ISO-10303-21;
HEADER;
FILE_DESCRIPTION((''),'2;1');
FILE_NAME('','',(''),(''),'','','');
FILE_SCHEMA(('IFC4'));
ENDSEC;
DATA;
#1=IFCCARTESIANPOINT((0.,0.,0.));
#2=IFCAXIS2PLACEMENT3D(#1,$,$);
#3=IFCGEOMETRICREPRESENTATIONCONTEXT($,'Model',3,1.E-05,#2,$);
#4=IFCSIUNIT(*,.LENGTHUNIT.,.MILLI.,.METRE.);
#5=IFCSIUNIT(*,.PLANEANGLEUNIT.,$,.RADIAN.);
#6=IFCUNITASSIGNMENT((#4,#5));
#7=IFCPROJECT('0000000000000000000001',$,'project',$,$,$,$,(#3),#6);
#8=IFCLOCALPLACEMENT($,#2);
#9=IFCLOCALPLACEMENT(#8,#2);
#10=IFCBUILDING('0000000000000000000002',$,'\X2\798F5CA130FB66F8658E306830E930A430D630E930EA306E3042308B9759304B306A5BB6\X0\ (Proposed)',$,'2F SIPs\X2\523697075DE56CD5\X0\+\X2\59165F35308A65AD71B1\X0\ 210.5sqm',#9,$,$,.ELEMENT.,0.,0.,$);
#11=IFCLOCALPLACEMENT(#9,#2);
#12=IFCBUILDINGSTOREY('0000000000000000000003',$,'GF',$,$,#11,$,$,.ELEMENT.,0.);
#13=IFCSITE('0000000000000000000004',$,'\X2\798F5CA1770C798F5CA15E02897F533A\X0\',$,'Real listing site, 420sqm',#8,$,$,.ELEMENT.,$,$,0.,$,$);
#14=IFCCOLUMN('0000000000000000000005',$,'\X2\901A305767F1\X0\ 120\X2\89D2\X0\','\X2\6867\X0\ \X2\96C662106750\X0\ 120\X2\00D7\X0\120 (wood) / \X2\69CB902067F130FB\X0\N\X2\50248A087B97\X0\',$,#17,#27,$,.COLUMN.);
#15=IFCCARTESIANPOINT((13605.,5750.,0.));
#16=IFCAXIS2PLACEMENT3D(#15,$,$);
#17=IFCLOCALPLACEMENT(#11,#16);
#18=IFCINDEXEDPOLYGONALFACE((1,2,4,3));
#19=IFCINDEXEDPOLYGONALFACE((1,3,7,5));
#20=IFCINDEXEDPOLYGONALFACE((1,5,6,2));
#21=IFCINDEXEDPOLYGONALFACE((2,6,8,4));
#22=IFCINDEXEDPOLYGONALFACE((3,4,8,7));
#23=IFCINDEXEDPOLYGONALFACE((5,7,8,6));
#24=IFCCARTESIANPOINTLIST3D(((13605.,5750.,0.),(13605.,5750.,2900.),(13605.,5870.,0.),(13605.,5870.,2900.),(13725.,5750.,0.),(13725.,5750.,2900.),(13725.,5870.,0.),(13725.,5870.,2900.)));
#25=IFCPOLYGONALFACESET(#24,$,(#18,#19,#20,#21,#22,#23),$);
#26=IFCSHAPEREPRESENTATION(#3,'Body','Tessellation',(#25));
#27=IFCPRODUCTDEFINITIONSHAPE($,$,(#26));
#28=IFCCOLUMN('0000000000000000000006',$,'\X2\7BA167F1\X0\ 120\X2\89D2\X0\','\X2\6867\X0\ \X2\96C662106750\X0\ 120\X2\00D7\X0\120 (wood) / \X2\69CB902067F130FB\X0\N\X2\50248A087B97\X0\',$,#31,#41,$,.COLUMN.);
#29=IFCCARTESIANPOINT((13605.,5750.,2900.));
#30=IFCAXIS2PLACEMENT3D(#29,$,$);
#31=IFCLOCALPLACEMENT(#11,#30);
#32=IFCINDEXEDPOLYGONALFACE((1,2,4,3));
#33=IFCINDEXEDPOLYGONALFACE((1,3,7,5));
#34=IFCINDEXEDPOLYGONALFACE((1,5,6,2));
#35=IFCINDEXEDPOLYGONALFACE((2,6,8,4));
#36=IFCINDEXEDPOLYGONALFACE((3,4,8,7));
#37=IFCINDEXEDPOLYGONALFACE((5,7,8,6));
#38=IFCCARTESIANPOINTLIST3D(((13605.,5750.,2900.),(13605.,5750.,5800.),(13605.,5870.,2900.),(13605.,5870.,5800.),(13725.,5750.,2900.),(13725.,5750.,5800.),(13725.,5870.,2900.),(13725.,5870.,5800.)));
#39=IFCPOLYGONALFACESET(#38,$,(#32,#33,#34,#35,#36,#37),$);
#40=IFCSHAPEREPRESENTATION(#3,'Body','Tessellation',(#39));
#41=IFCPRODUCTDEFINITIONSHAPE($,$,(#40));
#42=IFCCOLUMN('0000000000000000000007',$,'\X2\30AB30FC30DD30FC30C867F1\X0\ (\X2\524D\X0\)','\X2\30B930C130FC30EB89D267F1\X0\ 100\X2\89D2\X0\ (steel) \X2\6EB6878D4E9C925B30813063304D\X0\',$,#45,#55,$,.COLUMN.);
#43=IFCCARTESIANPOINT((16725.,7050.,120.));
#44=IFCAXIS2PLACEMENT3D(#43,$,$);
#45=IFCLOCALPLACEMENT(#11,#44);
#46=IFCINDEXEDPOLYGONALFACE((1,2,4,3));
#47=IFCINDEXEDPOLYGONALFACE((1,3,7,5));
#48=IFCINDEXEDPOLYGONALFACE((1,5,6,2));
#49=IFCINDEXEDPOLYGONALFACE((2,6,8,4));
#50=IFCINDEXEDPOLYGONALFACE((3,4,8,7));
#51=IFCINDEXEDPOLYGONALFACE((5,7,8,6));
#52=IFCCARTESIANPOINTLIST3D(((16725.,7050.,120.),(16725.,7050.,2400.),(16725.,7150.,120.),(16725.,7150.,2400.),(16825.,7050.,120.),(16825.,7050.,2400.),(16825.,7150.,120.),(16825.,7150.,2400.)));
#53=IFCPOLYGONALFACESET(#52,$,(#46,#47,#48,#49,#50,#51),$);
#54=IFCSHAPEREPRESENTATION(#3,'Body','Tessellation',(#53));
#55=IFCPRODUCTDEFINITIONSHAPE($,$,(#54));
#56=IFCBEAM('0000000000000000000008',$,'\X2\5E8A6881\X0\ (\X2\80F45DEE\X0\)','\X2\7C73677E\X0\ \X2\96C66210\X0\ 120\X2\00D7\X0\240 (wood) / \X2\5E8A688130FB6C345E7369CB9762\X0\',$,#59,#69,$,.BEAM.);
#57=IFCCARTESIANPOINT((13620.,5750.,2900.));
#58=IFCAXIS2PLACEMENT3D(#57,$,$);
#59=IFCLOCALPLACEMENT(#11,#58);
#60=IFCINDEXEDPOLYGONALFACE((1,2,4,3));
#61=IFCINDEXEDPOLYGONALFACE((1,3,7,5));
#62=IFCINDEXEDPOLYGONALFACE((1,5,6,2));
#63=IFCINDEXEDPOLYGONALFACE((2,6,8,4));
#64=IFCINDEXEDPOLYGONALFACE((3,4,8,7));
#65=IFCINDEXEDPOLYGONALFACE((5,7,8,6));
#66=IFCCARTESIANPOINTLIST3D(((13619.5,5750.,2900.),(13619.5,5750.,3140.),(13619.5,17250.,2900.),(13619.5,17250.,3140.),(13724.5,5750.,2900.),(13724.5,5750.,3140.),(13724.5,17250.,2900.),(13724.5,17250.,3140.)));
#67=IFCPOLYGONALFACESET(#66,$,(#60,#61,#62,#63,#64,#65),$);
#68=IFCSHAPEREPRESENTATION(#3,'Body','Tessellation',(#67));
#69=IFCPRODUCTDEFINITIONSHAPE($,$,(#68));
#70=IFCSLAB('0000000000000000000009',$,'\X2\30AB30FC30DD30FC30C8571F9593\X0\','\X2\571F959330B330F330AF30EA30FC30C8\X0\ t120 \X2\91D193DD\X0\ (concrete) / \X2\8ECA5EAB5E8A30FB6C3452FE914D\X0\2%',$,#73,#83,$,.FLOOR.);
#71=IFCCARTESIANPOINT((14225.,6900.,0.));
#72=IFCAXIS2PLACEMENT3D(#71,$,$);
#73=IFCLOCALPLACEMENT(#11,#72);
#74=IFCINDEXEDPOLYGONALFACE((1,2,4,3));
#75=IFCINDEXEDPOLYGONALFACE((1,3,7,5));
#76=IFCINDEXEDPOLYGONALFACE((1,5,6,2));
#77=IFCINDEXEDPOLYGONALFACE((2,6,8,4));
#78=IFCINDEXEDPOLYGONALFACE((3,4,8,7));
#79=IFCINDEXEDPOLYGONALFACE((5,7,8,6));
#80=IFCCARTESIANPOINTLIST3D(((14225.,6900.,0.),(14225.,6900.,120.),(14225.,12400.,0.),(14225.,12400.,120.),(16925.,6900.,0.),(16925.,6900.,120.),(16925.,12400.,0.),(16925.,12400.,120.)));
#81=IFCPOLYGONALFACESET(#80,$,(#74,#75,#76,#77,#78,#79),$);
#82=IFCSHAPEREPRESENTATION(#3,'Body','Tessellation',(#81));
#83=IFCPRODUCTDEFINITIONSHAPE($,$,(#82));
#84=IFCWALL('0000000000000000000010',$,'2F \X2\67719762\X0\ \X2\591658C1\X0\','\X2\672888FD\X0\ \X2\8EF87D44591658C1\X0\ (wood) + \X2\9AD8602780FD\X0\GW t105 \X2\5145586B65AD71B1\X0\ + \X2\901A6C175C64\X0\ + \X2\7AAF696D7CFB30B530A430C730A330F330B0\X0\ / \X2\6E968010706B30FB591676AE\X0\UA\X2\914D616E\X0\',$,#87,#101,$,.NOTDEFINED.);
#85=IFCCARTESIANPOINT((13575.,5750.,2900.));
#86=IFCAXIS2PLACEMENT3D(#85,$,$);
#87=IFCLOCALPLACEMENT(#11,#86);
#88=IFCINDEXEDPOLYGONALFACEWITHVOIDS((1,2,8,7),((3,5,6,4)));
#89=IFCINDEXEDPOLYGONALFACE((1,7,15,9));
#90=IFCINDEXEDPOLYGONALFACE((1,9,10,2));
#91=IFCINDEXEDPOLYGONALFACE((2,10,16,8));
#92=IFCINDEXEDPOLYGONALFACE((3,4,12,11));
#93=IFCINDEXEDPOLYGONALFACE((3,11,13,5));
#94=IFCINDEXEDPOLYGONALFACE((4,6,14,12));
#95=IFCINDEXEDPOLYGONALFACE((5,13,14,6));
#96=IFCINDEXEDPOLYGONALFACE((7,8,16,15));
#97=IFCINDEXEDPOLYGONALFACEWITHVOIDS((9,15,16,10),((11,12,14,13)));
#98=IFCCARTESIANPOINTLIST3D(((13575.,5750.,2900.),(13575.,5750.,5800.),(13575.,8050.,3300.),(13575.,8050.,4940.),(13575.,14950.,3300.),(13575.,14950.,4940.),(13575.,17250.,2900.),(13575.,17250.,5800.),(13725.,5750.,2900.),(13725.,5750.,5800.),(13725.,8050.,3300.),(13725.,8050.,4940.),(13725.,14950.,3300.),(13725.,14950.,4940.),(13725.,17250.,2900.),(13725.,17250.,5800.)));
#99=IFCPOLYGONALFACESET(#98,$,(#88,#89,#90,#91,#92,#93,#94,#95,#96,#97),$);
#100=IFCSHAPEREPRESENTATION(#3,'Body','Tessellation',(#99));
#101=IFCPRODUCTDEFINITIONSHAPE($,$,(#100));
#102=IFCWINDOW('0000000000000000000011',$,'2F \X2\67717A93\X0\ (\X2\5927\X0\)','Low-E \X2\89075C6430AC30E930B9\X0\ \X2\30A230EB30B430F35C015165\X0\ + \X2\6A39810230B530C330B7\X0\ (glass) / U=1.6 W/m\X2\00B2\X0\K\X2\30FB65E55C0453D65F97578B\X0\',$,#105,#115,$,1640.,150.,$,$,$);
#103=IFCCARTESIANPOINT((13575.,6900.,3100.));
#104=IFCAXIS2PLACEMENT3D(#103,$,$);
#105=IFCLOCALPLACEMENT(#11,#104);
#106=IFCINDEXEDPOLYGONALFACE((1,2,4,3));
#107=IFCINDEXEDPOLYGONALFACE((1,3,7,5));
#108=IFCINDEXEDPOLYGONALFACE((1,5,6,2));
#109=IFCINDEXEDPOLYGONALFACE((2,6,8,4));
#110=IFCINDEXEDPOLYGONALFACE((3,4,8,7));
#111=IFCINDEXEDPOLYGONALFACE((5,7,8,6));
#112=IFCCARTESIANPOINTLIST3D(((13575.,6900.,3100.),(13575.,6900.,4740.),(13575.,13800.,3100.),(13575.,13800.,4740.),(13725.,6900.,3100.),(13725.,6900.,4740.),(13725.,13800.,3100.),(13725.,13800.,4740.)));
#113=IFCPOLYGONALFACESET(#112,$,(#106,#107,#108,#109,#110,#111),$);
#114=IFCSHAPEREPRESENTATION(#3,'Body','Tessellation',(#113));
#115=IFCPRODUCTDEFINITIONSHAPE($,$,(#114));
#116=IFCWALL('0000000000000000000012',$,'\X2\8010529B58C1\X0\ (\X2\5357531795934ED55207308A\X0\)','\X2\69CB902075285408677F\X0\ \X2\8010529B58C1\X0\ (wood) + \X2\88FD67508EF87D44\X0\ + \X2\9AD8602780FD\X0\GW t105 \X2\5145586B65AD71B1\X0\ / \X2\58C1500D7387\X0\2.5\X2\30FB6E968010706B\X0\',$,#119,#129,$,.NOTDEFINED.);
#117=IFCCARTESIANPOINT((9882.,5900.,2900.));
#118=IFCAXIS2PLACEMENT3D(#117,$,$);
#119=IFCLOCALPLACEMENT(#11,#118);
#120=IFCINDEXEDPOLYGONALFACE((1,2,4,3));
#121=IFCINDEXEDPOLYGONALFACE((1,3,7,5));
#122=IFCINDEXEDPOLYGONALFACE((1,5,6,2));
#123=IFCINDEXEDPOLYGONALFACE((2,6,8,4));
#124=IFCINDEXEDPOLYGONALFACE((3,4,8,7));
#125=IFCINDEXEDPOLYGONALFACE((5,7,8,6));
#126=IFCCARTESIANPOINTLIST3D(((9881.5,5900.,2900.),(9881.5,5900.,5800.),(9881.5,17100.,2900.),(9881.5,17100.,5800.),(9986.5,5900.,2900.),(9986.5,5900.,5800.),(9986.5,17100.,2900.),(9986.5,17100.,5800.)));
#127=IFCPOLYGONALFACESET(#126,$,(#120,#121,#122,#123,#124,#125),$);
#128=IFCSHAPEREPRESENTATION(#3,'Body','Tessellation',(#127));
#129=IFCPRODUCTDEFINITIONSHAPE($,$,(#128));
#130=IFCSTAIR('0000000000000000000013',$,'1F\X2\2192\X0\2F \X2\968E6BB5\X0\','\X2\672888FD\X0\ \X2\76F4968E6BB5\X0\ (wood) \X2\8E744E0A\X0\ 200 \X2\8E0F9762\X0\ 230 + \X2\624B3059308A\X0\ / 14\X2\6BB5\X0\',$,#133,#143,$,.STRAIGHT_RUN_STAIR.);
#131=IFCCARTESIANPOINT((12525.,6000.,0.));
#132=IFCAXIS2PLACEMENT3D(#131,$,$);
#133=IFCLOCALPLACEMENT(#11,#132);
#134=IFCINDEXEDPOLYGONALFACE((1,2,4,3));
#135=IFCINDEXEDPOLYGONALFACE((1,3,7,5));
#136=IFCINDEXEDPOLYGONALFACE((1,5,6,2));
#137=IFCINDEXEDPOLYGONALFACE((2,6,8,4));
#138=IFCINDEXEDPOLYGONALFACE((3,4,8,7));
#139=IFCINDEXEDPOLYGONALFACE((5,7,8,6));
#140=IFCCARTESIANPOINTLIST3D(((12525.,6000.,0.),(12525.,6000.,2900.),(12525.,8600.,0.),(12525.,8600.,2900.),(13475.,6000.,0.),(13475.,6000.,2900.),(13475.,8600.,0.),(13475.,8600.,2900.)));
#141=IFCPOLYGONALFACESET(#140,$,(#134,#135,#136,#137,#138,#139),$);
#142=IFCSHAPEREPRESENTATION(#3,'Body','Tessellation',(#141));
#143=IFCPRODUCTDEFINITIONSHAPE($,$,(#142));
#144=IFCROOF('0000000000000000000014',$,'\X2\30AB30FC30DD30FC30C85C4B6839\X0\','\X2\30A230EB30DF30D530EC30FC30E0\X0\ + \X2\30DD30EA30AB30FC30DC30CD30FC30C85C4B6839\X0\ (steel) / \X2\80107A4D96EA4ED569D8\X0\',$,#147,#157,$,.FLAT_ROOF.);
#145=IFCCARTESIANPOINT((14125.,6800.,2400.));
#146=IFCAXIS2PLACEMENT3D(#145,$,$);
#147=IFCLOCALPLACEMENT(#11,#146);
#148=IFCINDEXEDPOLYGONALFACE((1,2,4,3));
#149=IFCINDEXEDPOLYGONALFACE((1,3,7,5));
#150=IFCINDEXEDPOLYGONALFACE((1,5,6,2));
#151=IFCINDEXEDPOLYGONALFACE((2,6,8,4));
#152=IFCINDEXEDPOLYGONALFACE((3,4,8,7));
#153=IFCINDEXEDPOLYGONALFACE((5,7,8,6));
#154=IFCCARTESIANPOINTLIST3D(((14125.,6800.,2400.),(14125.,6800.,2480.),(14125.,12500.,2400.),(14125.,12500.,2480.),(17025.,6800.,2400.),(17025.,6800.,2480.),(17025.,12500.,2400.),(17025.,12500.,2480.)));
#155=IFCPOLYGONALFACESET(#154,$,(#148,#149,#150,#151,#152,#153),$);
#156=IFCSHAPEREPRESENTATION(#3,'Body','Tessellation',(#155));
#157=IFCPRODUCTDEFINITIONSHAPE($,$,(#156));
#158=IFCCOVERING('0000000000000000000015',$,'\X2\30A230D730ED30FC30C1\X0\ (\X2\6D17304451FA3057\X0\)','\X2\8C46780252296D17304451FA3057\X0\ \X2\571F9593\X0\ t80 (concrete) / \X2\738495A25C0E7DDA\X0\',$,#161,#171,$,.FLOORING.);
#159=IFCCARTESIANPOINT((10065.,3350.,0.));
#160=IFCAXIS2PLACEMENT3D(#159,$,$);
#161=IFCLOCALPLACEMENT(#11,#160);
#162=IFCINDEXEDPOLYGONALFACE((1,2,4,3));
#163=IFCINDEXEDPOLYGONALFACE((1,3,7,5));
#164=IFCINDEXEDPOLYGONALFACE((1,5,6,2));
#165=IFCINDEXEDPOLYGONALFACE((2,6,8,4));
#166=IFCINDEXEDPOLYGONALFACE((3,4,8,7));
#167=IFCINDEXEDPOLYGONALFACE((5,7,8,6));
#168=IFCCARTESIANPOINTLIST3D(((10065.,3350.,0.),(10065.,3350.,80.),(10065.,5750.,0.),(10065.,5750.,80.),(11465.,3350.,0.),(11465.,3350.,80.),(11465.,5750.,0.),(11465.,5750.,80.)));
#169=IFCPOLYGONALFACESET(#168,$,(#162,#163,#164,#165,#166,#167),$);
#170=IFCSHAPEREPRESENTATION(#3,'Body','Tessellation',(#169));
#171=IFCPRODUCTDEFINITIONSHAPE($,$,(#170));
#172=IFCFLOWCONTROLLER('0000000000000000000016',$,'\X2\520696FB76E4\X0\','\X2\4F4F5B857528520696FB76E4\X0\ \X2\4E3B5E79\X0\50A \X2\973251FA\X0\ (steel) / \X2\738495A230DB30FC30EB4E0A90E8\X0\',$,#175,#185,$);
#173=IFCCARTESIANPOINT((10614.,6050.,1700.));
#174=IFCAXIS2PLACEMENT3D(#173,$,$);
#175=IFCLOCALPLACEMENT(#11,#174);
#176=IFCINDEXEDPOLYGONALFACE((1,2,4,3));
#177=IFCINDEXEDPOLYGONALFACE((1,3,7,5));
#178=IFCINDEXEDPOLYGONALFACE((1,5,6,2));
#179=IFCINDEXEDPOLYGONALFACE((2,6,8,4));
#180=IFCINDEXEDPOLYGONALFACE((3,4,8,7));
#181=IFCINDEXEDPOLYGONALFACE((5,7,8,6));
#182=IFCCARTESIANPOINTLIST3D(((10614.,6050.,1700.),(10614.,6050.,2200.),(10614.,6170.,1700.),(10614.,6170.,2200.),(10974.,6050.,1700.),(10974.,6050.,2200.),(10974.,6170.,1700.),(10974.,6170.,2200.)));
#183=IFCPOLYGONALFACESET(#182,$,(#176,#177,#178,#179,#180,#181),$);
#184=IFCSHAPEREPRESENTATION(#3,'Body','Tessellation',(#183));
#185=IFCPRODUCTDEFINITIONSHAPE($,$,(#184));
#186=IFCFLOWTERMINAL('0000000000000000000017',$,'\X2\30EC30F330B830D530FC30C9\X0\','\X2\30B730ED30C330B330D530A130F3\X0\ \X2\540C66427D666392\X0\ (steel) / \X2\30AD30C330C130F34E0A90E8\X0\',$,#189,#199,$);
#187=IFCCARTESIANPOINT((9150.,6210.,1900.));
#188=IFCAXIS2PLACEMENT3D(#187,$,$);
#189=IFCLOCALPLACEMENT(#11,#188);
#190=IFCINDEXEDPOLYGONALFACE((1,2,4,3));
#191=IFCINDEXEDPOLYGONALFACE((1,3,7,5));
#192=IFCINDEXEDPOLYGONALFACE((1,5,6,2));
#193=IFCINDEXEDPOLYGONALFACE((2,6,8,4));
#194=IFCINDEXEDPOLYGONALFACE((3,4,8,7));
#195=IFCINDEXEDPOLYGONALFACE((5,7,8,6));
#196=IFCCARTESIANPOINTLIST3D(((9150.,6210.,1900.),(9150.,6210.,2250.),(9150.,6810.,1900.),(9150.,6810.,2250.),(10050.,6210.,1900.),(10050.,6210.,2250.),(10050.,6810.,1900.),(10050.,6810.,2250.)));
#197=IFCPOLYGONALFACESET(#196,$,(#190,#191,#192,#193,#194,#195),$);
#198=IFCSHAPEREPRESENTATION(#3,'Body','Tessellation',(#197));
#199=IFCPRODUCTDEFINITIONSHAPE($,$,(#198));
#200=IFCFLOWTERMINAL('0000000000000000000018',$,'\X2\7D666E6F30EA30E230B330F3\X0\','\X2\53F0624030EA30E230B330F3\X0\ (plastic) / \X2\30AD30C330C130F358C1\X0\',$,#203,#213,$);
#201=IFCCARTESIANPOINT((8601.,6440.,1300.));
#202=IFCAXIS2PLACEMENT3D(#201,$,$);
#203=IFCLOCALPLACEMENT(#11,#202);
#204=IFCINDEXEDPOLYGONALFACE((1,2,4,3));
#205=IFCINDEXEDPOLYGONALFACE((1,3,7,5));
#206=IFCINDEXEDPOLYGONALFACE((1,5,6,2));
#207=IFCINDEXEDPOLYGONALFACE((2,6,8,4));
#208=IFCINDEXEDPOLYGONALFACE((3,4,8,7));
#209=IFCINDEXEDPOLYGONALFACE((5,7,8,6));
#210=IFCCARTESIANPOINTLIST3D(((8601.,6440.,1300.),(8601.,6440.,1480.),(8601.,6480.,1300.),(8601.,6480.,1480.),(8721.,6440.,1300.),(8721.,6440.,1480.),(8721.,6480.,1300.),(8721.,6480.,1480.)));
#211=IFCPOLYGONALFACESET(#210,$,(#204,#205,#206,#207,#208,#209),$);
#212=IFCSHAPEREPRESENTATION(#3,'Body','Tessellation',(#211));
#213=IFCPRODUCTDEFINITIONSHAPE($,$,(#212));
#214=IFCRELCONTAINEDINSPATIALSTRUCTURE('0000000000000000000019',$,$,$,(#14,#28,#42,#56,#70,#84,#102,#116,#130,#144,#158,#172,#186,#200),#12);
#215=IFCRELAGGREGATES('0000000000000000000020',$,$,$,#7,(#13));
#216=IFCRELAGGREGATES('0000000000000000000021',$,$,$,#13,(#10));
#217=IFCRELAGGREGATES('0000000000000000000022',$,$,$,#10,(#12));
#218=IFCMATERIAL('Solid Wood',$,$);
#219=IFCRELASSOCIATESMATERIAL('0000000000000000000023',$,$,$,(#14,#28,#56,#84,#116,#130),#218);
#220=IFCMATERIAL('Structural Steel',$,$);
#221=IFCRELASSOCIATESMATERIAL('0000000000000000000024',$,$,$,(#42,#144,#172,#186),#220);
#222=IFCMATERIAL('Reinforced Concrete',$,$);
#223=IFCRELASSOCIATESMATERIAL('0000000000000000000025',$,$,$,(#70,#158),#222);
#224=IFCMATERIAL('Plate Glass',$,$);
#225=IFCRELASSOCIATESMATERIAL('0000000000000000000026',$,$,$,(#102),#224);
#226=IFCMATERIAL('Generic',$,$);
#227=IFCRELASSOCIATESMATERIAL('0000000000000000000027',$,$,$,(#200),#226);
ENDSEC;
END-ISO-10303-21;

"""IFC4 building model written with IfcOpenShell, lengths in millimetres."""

from ifc_helpers import new_model, si_unit, frame, frame_2d, origin, place, context, project, spatial, rectangle, extrude, material, element, fill, save


model = new_model("IFC4")

# Units and contexts
model_context = context("Model", 3, precision=1e-05, world=origin())
ifc_project = project(units=[si_unit("LENGTHUNIT", "METRE", prefix="MILLI"), si_unit("PLANEANGLEUNIT", "RADIAN")], contexts=[model_context])

# Site, building, storey
site_placement = place(None, origin())
site = spatial("IfcSite", under=ifc_project, at=site_placement, Name="福岡県福岡市西区", ObjectType="Real listing site, 420sqm", CompositionType="ELEMENT", RefElevation=0.0)
building_placement = place(site_placement, origin())
building = spatial("IfcBuilding", under=site, at=building_placement, Name="福岡・書斎とライブラリのある静かな家 (Proposed)", ObjectType="2F SIPs制震工法+外張り断熱 210.5sqm", CompositionType="ELEMENT", ElevationOfRefHeight=0.0, ElevationOfTerrain=0.0)
storey_placement = place(building_placement, origin())
storey = spatial("IfcBuildingStorey", under=building, at=storey_placement, Name="GF", CompositionType="ELEMENT", Elevation=0.0)

# Columns
ifc_material_1 = material(Name="Solid Wood")
column_1_placement = place(storey_placement, frame((13605.0, 5750.0, 0.0)))
element("IfcColumn", 1, at=column_1_placement, inside=storey, material=ifc_material_1, Name="通し柱 120角", Description="桧 集成材 120×120 (wood) / 構造柱・N値計算", PredefinedType="COLUMN", context=model_context, shape_type="SweptSolid", body=[
    extrude(rectangle(XDim=120.0, YDim=120.0, at=frame_2d((60.0, 60.0))), frame((13605.0, 5750.0, 0.0)), (0.0, 0.0, 1.0), 2900.0),
])
column_2_placement = place(storey_placement, frame((13605.0, 5750.0, 2900.0)))
element("IfcColumn", 2, at=column_2_placement, inside=storey, material=ifc_material_1, Name="管柱 120角", Description="桧 集成材 120×120 (wood) / 構造柱・N値計算", PredefinedType="COLUMN", context=model_context, shape_type="SweptSolid", body=[
    extrude(rectangle(XDim=120.0, YDim=120.0, at=frame_2d((60.0, 60.0))), frame((13605.0, 5750.0, 2900.0)), (0.0, 0.0, 1.0), 2900.0),
])
ifc_material_2 = material(Name="Structural Steel")
column_3_placement = place(storey_placement, frame((16725.0, 7050.0, 120.0)))
element("IfcColumn", 3, at=column_3_placement, inside=storey, material=ifc_material_2, Name="カーポート柱 (前)", Description="スチール角柱 100角 (steel) 溶融亜鉛めっき", PredefinedType="COLUMN", context=model_context, shape_type="SweptSolid", body=[
    extrude(rectangle(XDim=100.0, YDim=100.0, at=frame_2d((50.0, 50.0))), frame((16725.0, 7050.0, 120.0)), (0.0, 0.0, 1.0), 2280.0),
])

# Beam
beam_1_placement = place(storey_placement, frame((13620.0, 5750.0, 2900.0)))
element("IfcBeam", 4, at=beam_1_placement, inside=storey, material=ifc_material_1, Name="床梁 (胴差)", Description="米松 集成 120×240 (wood) / 床梁・水平構面", PredefinedType="BEAM", context=model_context, shape_type="SweptSolid", body=[
    extrude(rectangle(XDim=105.0, YDim=11500.0, at=frame_2d((52.0, 5750.0))), frame((13620.0, 5750.0, 2900.0)), (0.0, 0.0, 1.0), 240.0),
])

# Slab
ifc_material_3 = material(Name="Reinforced Concrete")
slab_placement = place(storey_placement, frame((14225.0, 6900.0, 0.0)))
element("IfcSlab", 5, at=slab_placement, inside=storey, material=ifc_material_3, Name="カーポート土間", Description="土間コンクリート t120 金鏝 (concrete) / 車庫床・水勾配2%", PredefinedType="FLOOR", context=model_context, shape_type="SweptSolid", body=[
    extrude(rectangle(XDim=2700.0, YDim=5500.0, at=frame_2d((1350.0, 2750.0))), frame((14225.0, 6900.0, 0.0)), (0.0, 0.0, 1.0), 120.0),
])

# Shared definitions
ifc_material_4 = material(Name="Plate Glass")

# Wall, opening, window
wall_1_placement = place(storey_placement, frame((13575.0, 5750.0, 2900.0)))
wall_1 = element("IfcWall", 6, at=wall_1_placement, inside=storey, material=ifc_material_1, Name="2F 東面 外壁", Description="木製 軸組外壁 (wood) + 高性能GW t105 充填断熱 + 通気層 + 窯業系サイディング / 準耐火・外皮UA配慮", PredefinedType="NOTDEFINED", context=model_context, shape_type="SweptSolid", body=[
    extrude(rectangle(XDim=150.0, YDim=11500.0, at=frame_2d((75.0, 5750.0))), frame((13575.0, 5750.0, 2900.0)), (0.0, 0.0, 1.0), 2900.0),
])
opening_1_placement = place(storey_placement, frame((13575.0, 6900.0, 3100.0)))
opening_1 = element("IfcOpeningElement", 7, at=opening_1_placement, cuts=wall_1, PredefinedType="NOTDEFINED", context=model_context, shape_type="SweptSolid", body=[
    extrude(rectangle(XDim=150.0, YDim=6900.0, at=frame_2d((75.0, 3450.0))), frame((13575.0, 6900.0, 3100.0)), (0.0, 0.0, 1.0), 1640.0),
])
window_1_placement = place(storey_placement, frame((13575.0, 6900.0, 3100.0)))
window_1 = element("IfcWindow", 8, at=window_1_placement, inside=storey, material=ifc_material_4, Name="2F 東窓 (大)", Description="Low-E 複層ガラス アルゴン封入 + 樹脂サッシ (glass) / U=1.6 W/m²K・日射取得型", OverallHeight=1640.0, OverallWidth=150.0, context=model_context, shape_type="SweptSolid", body=[
    extrude(rectangle(XDim=150.0, YDim=6900.0, at=frame_2d((75.0, 3450.0))), frame((13575.0, 6900.0, 3100.0)), (0.0, 0.0, 1.0), 1640.0),
])
fill(opening_1, window_1)

# Wall
wall_2_placement = place(storey_placement, frame((9882.0, 5900.0, 2900.0)))
element("IfcWall", 9, at=wall_2_placement, inside=storey, material=ifc_material_1, Name="耐力壁 (南北間仕切り)", Description="構造用合板 耐力壁 (wood) + 製材軸組 + 高性能GW t105 充填断熱 / 壁倍率2.5・準耐火", PredefinedType="NOTDEFINED", context=model_context, shape_type="SweptSolid", body=[
    extrude(rectangle(XDim=105.0, YDim=11200.0, at=frame_2d((52.0, 5600.0))), frame((9882.0, 5900.0, 2900.0)), (0.0, 0.0, 1.0), 2900.0),
])

# Stair
stair_placement = place(storey_placement, frame((12525.0, 6000.0, 0.0)))
element("IfcStair", 10, at=stair_placement, inside=storey, material=ifc_material_1, Name="1F→2F 階段", Description="木製 直階段 (wood) 蹴上 200 踏面 230 + 手すり / 14段", PredefinedType="STRAIGHT_RUN_STAIR", context=model_context, shape_type="SweptSolid", body=[
    extrude(rectangle(XDim=950.0, YDim=2600.0, at=frame_2d((475.0, 1300.0))), frame((12525.0, 6000.0, 0.0)), (0.0, 0.0, 1.0), 2900.0),
])

# Roof
roof_placement = place(storey_placement, frame((14125.0, 6800.0, 2400.0)))
element("IfcRoof", 11, at=roof_placement, inside=storey, material=ifc_material_2, Name="カーポート屋根", Description="アルミフレーム + ポリカーボネート屋根 (steel) / 耐積雪仕様", PredefinedType="FLAT_ROOF", context=model_context, shape_type="SweptSolid", body=[
    extrude(rectangle(XDim=2900.0, YDim=5700.0, at=frame_2d((1450.0, 2850.0))), frame((14125.0, 6800.0, 2400.0)), (0.0, 0.0, 1.0), 80.0),
])

# Covering
covering_placement = place(storey_placement, frame((10065.0, 3350.0, 0.0)))
element("IfcCovering", 12, at=covering_placement, inside=storey, material=ifc_material_3, Name="アプローチ (洗い出し)", Description="豆砂利洗い出し 土間 t80 (concrete) / 玄関導線", PredefinedType="FLOORING", context=model_context, shape_type="SweptSolid", body=[
    extrude(rectangle(XDim=1400.0, YDim=2400.0, at=frame_2d((700.0, 1200.0))), frame((10065.0, 3350.0, 0.0)), (0.0, 0.0, 1.0), 80.0),
])

# Flow controller
flow_controller_placement = place(storey_placement, frame((10614.0, 6050.0, 1700.0)))
element("IfcFlowController", 13, at=flow_controller_placement, inside=storey, material=ifc_material_2, Name="分電盤", Description="住宅用分電盤 主幹50A 露出 (steel) / 玄関ホール上部", context=model_context, shape_type="SweptSolid", body=[
    extrude(rectangle(XDim=360.0, YDim=120.0, at=frame_2d((180.0, 60.0))), frame((10614.0, 6050.0, 1700.0)), (0.0, 0.0, 1.0), 500.0),
])

# Flow terminals
flow_terminal_1_placement = place(storey_placement, frame((9150.0, 6210.0, 1900.0)))
element("IfcFlowTerminal", 14, at=flow_terminal_1_placement, inside=storey, material=ifc_material_2, Name="レンジフード", Description="シロッコファン 同時給排 (steel) / キッチン上部", context=model_context, shape_type="SweptSolid", body=[
    extrude(rectangle(XDim=900.0, YDim=600.0, at=frame_2d((450.0, 300.0))), frame((9150.0, 6210.0, 1900.0)), (0.0, 0.0, 1.0), 350.0),
])
ifc_material_5 = material(Name="Generic")
flow_terminal_2_placement = place(storey_placement, frame((8601.0, 6440.0, 1300.0)))
element("IfcFlowTerminal", 15, at=flow_terminal_2_placement, inside=storey, material=ifc_material_5, Name="給湯リモコン", Description="台所リモコン (plastic) / キッチン壁", context=model_context, shape_type="SweptSolid", body=[
    extrude(rectangle(XDim=120.0, YDim=40.0, at=frame_2d((60.0, 20.0))), frame((8601.0, 6440.0, 1300.0)), (0.0, 0.0, 1.0), 180.0),
])

save(model, "model.ifc")
